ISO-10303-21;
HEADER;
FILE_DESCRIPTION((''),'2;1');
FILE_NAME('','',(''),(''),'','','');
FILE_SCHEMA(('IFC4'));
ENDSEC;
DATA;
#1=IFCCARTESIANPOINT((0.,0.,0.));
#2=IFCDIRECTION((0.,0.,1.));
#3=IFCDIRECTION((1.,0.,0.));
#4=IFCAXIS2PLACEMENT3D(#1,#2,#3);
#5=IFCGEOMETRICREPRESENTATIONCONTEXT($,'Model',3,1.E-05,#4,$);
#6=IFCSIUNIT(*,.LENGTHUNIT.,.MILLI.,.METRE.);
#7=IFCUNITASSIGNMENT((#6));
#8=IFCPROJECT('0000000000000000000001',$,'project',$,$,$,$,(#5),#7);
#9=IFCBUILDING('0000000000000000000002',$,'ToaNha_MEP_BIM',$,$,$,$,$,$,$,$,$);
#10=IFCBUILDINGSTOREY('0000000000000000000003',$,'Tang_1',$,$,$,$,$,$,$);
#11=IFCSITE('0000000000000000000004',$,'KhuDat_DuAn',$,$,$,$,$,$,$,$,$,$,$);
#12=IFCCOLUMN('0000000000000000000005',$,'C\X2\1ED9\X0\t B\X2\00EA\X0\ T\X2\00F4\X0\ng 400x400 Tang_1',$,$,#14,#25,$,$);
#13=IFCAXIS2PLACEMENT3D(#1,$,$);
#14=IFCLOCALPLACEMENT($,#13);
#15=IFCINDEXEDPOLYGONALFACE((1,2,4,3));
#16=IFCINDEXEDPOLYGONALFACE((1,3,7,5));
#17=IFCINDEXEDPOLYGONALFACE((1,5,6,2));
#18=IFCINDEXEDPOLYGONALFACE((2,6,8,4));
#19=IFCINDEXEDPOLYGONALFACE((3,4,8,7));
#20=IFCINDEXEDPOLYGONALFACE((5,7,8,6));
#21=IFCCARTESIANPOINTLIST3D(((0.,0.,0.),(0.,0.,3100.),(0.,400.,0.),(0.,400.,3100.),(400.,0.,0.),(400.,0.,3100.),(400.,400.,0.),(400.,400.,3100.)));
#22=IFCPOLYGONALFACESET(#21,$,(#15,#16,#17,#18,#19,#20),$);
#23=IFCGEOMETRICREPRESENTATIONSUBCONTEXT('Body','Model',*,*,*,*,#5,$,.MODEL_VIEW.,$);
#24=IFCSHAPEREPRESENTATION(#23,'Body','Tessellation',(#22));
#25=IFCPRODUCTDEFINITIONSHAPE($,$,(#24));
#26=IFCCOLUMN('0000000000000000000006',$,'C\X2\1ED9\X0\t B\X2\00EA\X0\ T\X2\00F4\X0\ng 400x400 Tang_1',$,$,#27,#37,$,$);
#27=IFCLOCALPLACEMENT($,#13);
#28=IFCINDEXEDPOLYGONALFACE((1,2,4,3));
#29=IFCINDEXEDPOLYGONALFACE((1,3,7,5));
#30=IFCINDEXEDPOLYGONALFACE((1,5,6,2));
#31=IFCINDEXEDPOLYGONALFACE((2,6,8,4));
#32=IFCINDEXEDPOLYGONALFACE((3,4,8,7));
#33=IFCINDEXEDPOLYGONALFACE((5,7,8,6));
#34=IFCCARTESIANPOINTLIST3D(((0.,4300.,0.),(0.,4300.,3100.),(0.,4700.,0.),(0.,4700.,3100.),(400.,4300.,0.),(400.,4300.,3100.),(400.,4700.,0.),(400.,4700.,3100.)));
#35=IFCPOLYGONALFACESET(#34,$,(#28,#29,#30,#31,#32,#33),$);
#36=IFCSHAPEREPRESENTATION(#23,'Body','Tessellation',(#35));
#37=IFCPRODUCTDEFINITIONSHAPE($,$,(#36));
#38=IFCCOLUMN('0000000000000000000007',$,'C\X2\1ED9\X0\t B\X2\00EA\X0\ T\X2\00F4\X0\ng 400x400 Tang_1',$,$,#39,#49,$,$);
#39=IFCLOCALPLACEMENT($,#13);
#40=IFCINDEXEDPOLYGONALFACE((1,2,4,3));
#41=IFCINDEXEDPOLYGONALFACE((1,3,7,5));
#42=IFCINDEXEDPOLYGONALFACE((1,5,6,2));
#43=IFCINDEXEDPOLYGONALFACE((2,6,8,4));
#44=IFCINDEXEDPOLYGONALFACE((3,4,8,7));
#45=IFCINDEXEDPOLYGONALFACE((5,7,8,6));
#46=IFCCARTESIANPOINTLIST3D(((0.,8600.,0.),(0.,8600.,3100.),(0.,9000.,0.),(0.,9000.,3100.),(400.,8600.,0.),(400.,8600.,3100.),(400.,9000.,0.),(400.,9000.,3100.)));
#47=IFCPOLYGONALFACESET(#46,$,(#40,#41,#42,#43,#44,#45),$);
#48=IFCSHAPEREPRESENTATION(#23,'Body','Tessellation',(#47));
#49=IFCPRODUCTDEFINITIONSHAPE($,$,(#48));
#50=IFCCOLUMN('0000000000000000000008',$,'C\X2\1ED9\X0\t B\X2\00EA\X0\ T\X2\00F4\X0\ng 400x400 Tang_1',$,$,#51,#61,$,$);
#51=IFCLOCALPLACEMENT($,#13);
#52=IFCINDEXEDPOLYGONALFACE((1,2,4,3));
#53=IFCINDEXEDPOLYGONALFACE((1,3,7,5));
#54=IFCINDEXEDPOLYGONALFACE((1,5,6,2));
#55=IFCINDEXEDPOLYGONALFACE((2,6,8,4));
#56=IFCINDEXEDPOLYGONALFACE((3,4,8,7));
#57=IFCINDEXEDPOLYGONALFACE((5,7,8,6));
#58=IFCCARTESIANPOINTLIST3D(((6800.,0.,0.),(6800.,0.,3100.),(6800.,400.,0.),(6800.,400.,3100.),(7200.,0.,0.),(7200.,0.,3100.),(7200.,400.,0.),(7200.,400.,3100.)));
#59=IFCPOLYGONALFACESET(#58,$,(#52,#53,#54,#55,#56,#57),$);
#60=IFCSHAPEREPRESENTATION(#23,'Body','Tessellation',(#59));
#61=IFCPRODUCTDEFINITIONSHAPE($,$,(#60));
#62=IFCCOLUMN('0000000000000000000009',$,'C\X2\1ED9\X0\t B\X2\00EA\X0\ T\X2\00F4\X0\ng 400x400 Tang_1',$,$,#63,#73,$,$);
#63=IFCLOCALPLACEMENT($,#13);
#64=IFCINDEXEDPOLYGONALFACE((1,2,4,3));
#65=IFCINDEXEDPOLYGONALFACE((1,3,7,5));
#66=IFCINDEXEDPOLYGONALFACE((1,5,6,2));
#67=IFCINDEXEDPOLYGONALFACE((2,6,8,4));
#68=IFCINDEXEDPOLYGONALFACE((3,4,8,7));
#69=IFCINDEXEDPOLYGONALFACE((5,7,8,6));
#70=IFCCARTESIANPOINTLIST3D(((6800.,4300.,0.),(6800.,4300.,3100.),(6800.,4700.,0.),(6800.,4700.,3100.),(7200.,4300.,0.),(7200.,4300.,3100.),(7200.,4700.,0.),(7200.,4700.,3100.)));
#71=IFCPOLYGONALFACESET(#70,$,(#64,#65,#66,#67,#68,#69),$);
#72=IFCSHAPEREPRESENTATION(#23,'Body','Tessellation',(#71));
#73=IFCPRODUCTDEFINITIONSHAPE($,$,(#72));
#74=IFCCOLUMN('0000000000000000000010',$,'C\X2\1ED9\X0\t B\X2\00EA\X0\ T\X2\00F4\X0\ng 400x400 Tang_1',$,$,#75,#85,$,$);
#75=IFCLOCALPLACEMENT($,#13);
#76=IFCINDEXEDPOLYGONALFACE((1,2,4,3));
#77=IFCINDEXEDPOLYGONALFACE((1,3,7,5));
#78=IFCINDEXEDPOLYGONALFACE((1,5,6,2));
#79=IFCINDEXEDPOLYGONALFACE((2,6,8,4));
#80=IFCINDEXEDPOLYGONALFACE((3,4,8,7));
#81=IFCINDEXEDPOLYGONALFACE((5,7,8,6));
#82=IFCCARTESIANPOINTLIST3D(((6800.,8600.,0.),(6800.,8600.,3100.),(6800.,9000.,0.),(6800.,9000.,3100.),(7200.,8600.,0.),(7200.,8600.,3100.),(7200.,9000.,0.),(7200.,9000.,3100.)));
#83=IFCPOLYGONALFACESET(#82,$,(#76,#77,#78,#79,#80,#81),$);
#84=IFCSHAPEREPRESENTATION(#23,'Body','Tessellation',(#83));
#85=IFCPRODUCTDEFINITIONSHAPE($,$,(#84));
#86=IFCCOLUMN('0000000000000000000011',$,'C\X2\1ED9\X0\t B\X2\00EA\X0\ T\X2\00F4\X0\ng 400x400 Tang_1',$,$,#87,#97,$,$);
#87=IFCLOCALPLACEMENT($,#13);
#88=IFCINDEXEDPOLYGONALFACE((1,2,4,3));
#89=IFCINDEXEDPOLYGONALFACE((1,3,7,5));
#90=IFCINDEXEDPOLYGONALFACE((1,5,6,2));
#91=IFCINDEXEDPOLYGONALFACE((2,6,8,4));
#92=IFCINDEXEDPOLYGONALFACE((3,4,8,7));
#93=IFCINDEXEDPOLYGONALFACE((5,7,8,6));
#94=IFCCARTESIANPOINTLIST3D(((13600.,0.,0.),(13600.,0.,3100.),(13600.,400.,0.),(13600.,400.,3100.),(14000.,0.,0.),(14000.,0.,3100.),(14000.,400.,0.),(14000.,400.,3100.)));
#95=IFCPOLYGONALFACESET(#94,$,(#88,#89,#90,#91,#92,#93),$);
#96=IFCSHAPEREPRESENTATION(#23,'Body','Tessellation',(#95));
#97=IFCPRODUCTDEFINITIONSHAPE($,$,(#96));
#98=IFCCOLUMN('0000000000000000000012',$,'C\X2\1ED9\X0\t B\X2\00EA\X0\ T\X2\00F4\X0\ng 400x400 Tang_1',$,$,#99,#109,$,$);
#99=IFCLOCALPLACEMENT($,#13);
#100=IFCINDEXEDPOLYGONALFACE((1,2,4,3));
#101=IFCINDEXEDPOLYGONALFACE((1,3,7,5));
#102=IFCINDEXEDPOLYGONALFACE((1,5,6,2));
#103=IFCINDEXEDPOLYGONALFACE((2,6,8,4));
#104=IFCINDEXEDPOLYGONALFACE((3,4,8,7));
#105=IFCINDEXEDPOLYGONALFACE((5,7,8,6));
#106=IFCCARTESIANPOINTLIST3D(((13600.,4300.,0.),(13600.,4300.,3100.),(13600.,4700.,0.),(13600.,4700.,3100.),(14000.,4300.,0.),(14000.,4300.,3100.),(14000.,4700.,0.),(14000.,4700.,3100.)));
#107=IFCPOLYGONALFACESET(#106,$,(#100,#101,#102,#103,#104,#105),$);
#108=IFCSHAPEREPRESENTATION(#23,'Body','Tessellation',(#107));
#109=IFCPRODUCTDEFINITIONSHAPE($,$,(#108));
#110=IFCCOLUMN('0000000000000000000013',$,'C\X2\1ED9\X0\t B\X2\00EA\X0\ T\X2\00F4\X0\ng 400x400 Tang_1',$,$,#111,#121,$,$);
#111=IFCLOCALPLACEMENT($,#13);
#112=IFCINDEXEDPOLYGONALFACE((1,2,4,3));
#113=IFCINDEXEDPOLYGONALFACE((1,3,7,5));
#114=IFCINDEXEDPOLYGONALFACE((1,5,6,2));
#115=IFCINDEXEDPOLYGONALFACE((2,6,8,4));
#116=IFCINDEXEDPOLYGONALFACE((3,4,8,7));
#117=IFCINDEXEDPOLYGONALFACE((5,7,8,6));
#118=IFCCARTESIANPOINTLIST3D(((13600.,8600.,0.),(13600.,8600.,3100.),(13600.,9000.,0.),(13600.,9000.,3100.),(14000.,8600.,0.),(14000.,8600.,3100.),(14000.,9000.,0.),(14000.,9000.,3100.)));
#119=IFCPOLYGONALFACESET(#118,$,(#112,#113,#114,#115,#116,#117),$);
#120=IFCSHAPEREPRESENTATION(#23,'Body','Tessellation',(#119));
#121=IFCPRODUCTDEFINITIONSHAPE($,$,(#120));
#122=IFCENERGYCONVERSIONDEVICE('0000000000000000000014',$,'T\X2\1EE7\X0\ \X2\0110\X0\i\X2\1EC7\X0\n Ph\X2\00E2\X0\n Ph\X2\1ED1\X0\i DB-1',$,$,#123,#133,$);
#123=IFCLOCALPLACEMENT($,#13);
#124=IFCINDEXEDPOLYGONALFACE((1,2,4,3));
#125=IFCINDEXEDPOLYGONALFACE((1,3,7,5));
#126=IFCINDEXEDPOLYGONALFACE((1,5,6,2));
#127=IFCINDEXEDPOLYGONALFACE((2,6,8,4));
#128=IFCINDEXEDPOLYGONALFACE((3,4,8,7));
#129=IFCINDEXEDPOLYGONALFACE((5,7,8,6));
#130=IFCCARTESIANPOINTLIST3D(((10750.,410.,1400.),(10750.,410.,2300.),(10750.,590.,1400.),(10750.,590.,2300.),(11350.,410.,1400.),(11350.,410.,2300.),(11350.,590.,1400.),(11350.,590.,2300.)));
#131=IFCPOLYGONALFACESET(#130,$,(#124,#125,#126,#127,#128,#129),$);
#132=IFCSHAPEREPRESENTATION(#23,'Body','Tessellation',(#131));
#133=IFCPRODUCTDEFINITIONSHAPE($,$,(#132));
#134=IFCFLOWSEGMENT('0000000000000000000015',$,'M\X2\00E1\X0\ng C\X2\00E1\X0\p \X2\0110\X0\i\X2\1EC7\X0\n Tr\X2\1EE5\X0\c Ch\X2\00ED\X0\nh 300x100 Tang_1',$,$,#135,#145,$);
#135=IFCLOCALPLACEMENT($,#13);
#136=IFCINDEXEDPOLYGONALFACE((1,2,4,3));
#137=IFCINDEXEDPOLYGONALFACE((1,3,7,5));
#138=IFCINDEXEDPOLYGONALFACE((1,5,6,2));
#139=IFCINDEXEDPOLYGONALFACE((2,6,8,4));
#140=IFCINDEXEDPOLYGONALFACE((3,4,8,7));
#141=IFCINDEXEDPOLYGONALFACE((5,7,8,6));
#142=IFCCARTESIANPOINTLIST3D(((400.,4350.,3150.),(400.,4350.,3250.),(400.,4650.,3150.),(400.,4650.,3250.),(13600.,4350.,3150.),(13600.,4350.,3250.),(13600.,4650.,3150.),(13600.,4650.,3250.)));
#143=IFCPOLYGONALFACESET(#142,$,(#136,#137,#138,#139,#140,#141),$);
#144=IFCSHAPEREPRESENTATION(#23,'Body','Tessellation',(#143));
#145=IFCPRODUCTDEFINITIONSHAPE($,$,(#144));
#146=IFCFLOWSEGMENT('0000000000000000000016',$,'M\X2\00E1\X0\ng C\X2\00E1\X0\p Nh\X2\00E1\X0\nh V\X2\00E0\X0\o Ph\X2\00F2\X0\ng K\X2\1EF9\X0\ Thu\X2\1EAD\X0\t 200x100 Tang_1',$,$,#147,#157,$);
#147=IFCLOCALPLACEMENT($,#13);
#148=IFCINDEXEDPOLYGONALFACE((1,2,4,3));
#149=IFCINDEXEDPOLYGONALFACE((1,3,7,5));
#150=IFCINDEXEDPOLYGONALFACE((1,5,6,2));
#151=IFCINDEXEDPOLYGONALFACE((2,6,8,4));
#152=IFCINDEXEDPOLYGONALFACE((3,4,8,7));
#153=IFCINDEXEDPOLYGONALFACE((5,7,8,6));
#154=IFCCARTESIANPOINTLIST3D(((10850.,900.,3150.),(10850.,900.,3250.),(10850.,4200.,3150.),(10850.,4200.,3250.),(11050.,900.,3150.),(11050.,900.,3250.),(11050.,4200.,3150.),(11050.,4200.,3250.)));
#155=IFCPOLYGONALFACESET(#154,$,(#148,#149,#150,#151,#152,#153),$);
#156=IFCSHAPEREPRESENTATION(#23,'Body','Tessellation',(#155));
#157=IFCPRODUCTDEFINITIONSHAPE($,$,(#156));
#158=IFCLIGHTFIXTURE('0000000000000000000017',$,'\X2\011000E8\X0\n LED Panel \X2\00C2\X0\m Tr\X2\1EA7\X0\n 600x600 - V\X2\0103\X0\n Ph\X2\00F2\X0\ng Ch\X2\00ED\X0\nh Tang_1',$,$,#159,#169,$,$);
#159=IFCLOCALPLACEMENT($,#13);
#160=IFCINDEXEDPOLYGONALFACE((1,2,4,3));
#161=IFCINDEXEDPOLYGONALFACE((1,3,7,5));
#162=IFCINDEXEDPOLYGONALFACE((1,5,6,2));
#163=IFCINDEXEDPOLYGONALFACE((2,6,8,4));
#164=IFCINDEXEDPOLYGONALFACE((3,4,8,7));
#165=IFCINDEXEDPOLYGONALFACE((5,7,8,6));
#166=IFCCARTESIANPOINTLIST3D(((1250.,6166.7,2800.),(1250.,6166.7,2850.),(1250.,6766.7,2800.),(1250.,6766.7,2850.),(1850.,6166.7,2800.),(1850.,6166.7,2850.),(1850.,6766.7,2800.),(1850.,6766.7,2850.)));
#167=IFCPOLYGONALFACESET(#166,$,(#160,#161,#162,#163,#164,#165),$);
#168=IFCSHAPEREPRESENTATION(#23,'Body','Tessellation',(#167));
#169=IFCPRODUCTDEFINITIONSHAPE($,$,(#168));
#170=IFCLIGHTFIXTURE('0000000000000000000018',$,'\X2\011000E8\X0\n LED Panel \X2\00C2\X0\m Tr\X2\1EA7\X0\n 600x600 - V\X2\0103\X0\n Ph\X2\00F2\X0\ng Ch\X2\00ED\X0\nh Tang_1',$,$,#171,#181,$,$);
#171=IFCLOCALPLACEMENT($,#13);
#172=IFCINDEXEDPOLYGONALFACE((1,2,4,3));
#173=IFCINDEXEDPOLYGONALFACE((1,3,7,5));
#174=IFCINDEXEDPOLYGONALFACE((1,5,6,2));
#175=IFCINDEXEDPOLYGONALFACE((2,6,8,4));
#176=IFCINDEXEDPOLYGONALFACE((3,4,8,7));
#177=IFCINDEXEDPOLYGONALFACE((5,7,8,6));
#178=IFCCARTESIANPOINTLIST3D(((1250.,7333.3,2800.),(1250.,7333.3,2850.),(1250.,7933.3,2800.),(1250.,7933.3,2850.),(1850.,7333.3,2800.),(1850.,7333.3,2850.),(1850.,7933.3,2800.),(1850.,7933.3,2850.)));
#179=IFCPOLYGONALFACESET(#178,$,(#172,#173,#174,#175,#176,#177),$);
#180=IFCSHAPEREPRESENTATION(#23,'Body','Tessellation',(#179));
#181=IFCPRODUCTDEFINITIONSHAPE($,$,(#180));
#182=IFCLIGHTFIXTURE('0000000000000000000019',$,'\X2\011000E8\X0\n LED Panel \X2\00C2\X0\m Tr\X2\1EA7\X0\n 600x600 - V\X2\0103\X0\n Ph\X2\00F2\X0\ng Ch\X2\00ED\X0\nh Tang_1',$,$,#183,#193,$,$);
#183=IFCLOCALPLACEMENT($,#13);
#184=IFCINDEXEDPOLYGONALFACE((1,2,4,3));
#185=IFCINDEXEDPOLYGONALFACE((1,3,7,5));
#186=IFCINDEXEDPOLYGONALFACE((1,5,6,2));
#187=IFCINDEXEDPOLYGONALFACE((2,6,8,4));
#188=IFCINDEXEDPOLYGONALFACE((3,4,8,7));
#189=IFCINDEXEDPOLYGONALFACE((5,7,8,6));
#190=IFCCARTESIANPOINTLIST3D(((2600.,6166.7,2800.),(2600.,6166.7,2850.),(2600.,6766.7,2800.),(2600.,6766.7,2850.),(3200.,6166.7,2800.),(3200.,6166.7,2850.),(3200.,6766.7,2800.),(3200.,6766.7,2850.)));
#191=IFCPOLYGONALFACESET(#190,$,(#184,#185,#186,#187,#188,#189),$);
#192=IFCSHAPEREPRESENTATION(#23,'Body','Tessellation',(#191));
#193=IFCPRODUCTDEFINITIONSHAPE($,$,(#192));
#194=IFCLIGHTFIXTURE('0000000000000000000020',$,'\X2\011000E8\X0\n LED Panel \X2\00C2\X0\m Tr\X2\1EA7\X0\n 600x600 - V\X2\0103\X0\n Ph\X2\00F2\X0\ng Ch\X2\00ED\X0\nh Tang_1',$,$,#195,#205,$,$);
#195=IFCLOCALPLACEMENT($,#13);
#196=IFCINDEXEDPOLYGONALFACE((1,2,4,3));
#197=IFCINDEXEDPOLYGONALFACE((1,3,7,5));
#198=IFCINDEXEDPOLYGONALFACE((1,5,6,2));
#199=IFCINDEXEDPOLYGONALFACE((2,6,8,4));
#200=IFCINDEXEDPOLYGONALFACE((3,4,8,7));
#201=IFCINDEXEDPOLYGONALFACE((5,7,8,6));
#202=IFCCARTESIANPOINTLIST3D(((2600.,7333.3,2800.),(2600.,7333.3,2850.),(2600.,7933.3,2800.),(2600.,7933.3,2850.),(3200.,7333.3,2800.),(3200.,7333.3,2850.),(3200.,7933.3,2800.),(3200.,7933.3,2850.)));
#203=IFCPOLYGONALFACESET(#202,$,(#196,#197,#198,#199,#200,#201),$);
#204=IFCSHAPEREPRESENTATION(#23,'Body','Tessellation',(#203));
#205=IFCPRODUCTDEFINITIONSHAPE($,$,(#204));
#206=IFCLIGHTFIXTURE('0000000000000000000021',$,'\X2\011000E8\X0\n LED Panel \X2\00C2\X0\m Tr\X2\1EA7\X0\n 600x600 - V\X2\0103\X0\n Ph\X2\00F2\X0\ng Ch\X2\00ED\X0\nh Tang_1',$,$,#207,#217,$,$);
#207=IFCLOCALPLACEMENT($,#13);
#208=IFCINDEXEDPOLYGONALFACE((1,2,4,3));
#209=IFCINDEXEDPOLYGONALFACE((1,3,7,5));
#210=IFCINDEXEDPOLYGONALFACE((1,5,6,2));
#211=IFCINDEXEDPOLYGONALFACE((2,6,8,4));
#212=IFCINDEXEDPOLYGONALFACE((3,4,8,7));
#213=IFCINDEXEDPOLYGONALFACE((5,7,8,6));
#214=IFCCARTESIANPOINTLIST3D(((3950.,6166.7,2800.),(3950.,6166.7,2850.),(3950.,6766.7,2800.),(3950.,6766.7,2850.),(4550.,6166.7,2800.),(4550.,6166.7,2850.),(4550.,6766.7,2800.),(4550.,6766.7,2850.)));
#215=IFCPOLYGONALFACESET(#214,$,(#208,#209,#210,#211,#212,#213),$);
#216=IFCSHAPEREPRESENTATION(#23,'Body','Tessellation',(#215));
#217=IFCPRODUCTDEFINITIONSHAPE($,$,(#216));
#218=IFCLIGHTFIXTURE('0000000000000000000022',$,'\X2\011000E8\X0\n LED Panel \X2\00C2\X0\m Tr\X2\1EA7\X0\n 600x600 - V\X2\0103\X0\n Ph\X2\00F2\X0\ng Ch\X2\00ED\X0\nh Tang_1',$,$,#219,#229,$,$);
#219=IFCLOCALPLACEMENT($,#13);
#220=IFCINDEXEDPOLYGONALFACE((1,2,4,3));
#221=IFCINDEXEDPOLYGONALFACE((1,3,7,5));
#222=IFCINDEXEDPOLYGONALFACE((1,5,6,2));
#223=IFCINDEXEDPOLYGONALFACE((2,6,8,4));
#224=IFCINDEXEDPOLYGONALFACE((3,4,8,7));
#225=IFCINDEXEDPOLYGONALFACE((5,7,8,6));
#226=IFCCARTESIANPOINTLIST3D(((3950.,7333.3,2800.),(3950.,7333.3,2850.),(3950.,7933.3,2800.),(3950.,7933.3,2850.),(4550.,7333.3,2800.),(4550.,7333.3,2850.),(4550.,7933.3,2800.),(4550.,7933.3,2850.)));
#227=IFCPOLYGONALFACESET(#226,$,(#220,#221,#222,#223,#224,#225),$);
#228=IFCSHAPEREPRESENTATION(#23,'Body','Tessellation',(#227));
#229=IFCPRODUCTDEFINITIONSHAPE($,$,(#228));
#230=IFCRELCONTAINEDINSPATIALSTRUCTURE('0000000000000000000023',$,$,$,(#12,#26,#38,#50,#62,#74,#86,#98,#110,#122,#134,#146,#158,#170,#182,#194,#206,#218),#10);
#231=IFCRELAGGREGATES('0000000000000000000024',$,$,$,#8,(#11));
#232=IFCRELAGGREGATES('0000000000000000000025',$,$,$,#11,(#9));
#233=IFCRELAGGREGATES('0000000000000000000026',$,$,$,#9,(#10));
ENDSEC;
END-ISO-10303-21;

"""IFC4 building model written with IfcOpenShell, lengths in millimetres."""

from ifc_helpers import new_model, si_unit, frame, origin_with_axes, context, subcontext, project, spatial, polyline, outline, extrude, element, save


model = new_model("IFC4")

# Units and contexts
model_context = context("Model", 3, precision=1e-05, world=origin_with_axes())
body_context = subcontext(model_context, "Body", "Model", "MODEL_VIEW")
ifc_project = project(units=[si_unit("LENGTHUNIT", "METRE", prefix="MILLI")], contexts=[model_context])

# Site, building, storey
site = spatial("IfcSite", under=ifc_project, Name="KhuDat_DuAn")
building = spatial("IfcBuilding", under=site, Name="ToaNha_MEP_BIM")
storey = spatial("IfcBuildingStorey", under=building, Name="Tang_1")

# Columns
element("IfcColumn", 1, inside=storey, Name="Cột Bê Tông 400x400 Tang_1", context=body_context, shape_type="SweptSolid", body=[
    extrude(outline(polyline([(0.0, 0.0), (400.0, 0.0), (400.0, 400.0), (0.0, 400.0), (0.0, 0.0)])), origin_with_axes(), (0.0, 0.0, 1.0), 3100.0),
])
element("IfcColumn", 2, inside=storey, Name="Cột Bê Tông 400x400 Tang_1", context=body_context, shape_type="SweptSolid", body=[
    extrude(outline(polyline([(0.0, 4300.0), (400.0, 4300.0), (400.0, 4700.0), (0.0, 4700.0), (0.0, 4300.0)])), origin_with_axes(), (0.0, 0.0, 1.0), 3100.0),
])
element("IfcColumn", 3, inside=storey, Name="Cột Bê Tông 400x400 Tang_1", context=body_context, shape_type="SweptSolid", body=[
    extrude(outline(polyline([(0.0, 8600.0), (400.0, 8600.0), (400.0, 9000.0), (0.0, 9000.0), (0.0, 8600.0)])), origin_with_axes(), (0.0, 0.0, 1.0), 3100.0),
])
element("IfcColumn", 4, inside=storey, Name="Cột Bê Tông 400x400 Tang_1", context=body_context, shape_type="SweptSolid", body=[
    extrude(outline(polyline([(6800.0, 0.0), (7200.0, 0.0), (7200.0, 400.0), (6800.0, 400.0), (6800.0, 0.0)])), origin_with_axes(), (0.0, 0.0, 1.0), 3100.0),
])
element("IfcColumn", 5, inside=storey, Name="Cột Bê Tông 400x400 Tang_1", context=body_context, shape_type="SweptSolid", body=[
    extrude(outline(polyline([(6800.0, 4300.0), (7200.0, 4300.0), (7200.0, 4700.0), (6800.0, 4700.0), (6800.0, 4300.0)])), origin_with_axes(), (0.0, 0.0, 1.0), 3100.0),
])
element("IfcColumn", 6, inside=storey, Name="Cột Bê Tông 400x400 Tang_1", context=body_context, shape_type="SweptSolid", body=[
    extrude(outline(polyline([(6800.0, 8600.0), (7200.0, 8600.0), (7200.0, 9000.0), (6800.0, 9000.0), (6800.0, 8600.0)])), origin_with_axes(), (0.0, 0.0, 1.0), 3100.0),
])
element("IfcColumn", 7, inside=storey, Name="Cột Bê Tông 400x400 Tang_1", context=body_context, shape_type="SweptSolid", body=[
    extrude(outline(polyline([(13600.0, 0.0), (14000.0, 0.0), (14000.0, 400.0), (13600.0, 400.0), (13600.0, 0.0)])), origin_with_axes(), (0.0, 0.0, 1.0), 3100.0),
])
element("IfcColumn", 8, inside=storey, Name="Cột Bê Tông 400x400 Tang_1", context=body_context, shape_type="SweptSolid", body=[
    extrude(outline(polyline([(13600.0, 4300.0), (14000.0, 4300.0), (14000.0, 4700.0), (13600.0, 4700.0), (13600.0, 4300.0)])), origin_with_axes(), (0.0, 0.0, 1.0), 3100.0),
])
element("IfcColumn", 9, inside=storey, Name="Cột Bê Tông 400x400 Tang_1", context=body_context, shape_type="SweptSolid", body=[
    extrude(outline(polyline([(13600.0, 8600.0), (14000.0, 8600.0), (14000.0, 9000.0), (13600.0, 9000.0), (13600.0, 8600.0)])), origin_with_axes(), (0.0, 0.0, 1.0), 3100.0),
])

# Energy conversion device
element("IfcEnergyConversionDevice", 10, inside=storey, Name="Tủ Điện Phân Phối DB-1", context=body_context, shape_type="SweptSolid", body=[
    extrude(outline(polyline([(10750.0, 410.0), (11350.0, 410.0), (11350.0, 590.0), (10750.0, 590.0), (10750.0, 410.0)])), frame((0.0, 0.0, 1400.0), z_axis=(0.0, 0.0, 1.0), x_axis=(1.0, 0.0, 0.0)), (0.0, 0.0, 1.0), 900.0),
])

# Flow segments
element("IfcFlowSegment", 11, inside=storey, Name="Máng Cáp Điện Trục Chính 300x100 Tang_1", context=body_context, shape_type="SweptSolid", body=[
    extrude(outline(polyline([(400.0, 4350.0), (13600.0, 4350.0), (13600.0, 4650.0), (400.0, 4650.0), (400.0, 4350.0)])), frame((0.0, 0.0, 3150.0), z_axis=(0.0, 0.0, 1.0), x_axis=(1.0, 0.0, 0.0)), (0.0, 0.0, 1.0), 100.0),
])
element("IfcFlowSegment", 12, inside=storey, Name="Máng Cáp Nhánh Vào Phòng Kỹ Thuật 200x100 Tang_1", context=body_context, shape_type="SweptSolid", body=[
    extrude(outline(polyline([(10850.0, 900.0), (11050.0, 900.0), (11050.0, 4200.0), (10850.0, 4200.0), (10850.0, 900.0)])), frame((0.0, 0.0, 3150.0), z_axis=(0.0, 0.0, 1.0), x_axis=(1.0, 0.0, 0.0)), (0.0, 0.0, 1.0), 100.0),
])

# Light fixtures
element("IfcLightFixture", 13, inside=storey, Name="Đèn LED Panel Âm Trần 600x600 - Văn Phòng Chính Tang_1", context=body_context, shape_type="SweptSolid", body=[
    extrude(outline(polyline([(1250.0, 6166.7), (1850.0, 6166.7), (1850.0, 6766.7), (1250.0, 6766.7), (1250.0, 6166.7)])), frame((0.0, 0.0, 2800.0), z_axis=(0.0, 0.0, 1.0), x_axis=(1.0, 0.0, 0.0)), (0.0, 0.0, 1.0), 50.0),
])
element("IfcLightFixture", 14, inside=storey, Name="Đèn LED Panel Âm Trần 600x600 - Văn Phòng Chính Tang_1", context=body_context, shape_type="SweptSolid", body=[
    extrude(outline(polyline([(1250.0, 7333.3), (1850.0, 7333.3), (1850.0, 7933.3), (1250.0, 7933.3), (1250.0, 7333.3)])), frame((0.0, 0.0, 2800.0), z_axis=(0.0, 0.0, 1.0), x_axis=(1.0, 0.0, 0.0)), (0.0, 0.0, 1.0), 50.0),
])
element("IfcLightFixture", 15, inside=storey, Name="Đèn LED Panel Âm Trần 600x600 - Văn Phòng Chính Tang_1", context=body_context, shape_type="SweptSolid", body=[
    extrude(outline(polyline([(2600.0, 6166.7), (3200.0, 6166.7), (3200.0, 6766.7), (2600.0, 6766.7), (2600.0, 6166.7)])), frame((0.0, 0.0, 2800.0), z_axis=(0.0, 0.0, 1.0), x_axis=(1.0, 0.0, 0.0)), (0.0, 0.0, 1.0), 50.0),
])
element("IfcLightFixture", 16, inside=storey, Name="Đèn LED Panel Âm Trần 600x600 - Văn Phòng Chính Tang_1", context=body_context, shape_type="SweptSolid", body=[
    extrude(outline(polyline([(2600.0, 7333.3), (3200.0, 7333.3), (3200.0, 7933.3), (2600.0, 7933.3), (2600.0, 7333.3)])), frame((0.0, 0.0, 2800.0), z_axis=(0.0, 0.0, 1.0), x_axis=(1.0, 0.0, 0.0)), (0.0, 0.0, 1.0), 50.0),
])
element("IfcLightFixture", 17, inside=storey, Name="Đèn LED Panel Âm Trần 600x600 - Văn Phòng Chính Tang_1", context=body_context, shape_type="SweptSolid", body=[
    extrude(outline(polyline([(3950.0, 6166.7), (4550.0, 6166.7), (4550.0, 6766.7), (3950.0, 6766.7), (3950.0, 6166.7)])), frame((0.0, 0.0, 2800.0), z_axis=(0.0, 0.0, 1.0), x_axis=(1.0, 0.0, 0.0)), (0.0, 0.0, 1.0), 50.0),
])
element("IfcLightFixture", 18, inside=storey, Name="Đèn LED Panel Âm Trần 600x600 - Văn Phòng Chính Tang_1", context=body_context, shape_type="SweptSolid", body=[
    extrude(outline(polyline([(3950.0, 7333.3), (4550.0, 7333.3), (4550.0, 7933.3), (3950.0, 7933.3), (3950.0, 7333.3)])), frame((0.0, 0.0, 2800.0), z_axis=(0.0, 0.0, 1.0), x_axis=(1.0, 0.0, 0.0)), (0.0, 0.0, 1.0), 50.0),
])

save(model, "model.ifc")
